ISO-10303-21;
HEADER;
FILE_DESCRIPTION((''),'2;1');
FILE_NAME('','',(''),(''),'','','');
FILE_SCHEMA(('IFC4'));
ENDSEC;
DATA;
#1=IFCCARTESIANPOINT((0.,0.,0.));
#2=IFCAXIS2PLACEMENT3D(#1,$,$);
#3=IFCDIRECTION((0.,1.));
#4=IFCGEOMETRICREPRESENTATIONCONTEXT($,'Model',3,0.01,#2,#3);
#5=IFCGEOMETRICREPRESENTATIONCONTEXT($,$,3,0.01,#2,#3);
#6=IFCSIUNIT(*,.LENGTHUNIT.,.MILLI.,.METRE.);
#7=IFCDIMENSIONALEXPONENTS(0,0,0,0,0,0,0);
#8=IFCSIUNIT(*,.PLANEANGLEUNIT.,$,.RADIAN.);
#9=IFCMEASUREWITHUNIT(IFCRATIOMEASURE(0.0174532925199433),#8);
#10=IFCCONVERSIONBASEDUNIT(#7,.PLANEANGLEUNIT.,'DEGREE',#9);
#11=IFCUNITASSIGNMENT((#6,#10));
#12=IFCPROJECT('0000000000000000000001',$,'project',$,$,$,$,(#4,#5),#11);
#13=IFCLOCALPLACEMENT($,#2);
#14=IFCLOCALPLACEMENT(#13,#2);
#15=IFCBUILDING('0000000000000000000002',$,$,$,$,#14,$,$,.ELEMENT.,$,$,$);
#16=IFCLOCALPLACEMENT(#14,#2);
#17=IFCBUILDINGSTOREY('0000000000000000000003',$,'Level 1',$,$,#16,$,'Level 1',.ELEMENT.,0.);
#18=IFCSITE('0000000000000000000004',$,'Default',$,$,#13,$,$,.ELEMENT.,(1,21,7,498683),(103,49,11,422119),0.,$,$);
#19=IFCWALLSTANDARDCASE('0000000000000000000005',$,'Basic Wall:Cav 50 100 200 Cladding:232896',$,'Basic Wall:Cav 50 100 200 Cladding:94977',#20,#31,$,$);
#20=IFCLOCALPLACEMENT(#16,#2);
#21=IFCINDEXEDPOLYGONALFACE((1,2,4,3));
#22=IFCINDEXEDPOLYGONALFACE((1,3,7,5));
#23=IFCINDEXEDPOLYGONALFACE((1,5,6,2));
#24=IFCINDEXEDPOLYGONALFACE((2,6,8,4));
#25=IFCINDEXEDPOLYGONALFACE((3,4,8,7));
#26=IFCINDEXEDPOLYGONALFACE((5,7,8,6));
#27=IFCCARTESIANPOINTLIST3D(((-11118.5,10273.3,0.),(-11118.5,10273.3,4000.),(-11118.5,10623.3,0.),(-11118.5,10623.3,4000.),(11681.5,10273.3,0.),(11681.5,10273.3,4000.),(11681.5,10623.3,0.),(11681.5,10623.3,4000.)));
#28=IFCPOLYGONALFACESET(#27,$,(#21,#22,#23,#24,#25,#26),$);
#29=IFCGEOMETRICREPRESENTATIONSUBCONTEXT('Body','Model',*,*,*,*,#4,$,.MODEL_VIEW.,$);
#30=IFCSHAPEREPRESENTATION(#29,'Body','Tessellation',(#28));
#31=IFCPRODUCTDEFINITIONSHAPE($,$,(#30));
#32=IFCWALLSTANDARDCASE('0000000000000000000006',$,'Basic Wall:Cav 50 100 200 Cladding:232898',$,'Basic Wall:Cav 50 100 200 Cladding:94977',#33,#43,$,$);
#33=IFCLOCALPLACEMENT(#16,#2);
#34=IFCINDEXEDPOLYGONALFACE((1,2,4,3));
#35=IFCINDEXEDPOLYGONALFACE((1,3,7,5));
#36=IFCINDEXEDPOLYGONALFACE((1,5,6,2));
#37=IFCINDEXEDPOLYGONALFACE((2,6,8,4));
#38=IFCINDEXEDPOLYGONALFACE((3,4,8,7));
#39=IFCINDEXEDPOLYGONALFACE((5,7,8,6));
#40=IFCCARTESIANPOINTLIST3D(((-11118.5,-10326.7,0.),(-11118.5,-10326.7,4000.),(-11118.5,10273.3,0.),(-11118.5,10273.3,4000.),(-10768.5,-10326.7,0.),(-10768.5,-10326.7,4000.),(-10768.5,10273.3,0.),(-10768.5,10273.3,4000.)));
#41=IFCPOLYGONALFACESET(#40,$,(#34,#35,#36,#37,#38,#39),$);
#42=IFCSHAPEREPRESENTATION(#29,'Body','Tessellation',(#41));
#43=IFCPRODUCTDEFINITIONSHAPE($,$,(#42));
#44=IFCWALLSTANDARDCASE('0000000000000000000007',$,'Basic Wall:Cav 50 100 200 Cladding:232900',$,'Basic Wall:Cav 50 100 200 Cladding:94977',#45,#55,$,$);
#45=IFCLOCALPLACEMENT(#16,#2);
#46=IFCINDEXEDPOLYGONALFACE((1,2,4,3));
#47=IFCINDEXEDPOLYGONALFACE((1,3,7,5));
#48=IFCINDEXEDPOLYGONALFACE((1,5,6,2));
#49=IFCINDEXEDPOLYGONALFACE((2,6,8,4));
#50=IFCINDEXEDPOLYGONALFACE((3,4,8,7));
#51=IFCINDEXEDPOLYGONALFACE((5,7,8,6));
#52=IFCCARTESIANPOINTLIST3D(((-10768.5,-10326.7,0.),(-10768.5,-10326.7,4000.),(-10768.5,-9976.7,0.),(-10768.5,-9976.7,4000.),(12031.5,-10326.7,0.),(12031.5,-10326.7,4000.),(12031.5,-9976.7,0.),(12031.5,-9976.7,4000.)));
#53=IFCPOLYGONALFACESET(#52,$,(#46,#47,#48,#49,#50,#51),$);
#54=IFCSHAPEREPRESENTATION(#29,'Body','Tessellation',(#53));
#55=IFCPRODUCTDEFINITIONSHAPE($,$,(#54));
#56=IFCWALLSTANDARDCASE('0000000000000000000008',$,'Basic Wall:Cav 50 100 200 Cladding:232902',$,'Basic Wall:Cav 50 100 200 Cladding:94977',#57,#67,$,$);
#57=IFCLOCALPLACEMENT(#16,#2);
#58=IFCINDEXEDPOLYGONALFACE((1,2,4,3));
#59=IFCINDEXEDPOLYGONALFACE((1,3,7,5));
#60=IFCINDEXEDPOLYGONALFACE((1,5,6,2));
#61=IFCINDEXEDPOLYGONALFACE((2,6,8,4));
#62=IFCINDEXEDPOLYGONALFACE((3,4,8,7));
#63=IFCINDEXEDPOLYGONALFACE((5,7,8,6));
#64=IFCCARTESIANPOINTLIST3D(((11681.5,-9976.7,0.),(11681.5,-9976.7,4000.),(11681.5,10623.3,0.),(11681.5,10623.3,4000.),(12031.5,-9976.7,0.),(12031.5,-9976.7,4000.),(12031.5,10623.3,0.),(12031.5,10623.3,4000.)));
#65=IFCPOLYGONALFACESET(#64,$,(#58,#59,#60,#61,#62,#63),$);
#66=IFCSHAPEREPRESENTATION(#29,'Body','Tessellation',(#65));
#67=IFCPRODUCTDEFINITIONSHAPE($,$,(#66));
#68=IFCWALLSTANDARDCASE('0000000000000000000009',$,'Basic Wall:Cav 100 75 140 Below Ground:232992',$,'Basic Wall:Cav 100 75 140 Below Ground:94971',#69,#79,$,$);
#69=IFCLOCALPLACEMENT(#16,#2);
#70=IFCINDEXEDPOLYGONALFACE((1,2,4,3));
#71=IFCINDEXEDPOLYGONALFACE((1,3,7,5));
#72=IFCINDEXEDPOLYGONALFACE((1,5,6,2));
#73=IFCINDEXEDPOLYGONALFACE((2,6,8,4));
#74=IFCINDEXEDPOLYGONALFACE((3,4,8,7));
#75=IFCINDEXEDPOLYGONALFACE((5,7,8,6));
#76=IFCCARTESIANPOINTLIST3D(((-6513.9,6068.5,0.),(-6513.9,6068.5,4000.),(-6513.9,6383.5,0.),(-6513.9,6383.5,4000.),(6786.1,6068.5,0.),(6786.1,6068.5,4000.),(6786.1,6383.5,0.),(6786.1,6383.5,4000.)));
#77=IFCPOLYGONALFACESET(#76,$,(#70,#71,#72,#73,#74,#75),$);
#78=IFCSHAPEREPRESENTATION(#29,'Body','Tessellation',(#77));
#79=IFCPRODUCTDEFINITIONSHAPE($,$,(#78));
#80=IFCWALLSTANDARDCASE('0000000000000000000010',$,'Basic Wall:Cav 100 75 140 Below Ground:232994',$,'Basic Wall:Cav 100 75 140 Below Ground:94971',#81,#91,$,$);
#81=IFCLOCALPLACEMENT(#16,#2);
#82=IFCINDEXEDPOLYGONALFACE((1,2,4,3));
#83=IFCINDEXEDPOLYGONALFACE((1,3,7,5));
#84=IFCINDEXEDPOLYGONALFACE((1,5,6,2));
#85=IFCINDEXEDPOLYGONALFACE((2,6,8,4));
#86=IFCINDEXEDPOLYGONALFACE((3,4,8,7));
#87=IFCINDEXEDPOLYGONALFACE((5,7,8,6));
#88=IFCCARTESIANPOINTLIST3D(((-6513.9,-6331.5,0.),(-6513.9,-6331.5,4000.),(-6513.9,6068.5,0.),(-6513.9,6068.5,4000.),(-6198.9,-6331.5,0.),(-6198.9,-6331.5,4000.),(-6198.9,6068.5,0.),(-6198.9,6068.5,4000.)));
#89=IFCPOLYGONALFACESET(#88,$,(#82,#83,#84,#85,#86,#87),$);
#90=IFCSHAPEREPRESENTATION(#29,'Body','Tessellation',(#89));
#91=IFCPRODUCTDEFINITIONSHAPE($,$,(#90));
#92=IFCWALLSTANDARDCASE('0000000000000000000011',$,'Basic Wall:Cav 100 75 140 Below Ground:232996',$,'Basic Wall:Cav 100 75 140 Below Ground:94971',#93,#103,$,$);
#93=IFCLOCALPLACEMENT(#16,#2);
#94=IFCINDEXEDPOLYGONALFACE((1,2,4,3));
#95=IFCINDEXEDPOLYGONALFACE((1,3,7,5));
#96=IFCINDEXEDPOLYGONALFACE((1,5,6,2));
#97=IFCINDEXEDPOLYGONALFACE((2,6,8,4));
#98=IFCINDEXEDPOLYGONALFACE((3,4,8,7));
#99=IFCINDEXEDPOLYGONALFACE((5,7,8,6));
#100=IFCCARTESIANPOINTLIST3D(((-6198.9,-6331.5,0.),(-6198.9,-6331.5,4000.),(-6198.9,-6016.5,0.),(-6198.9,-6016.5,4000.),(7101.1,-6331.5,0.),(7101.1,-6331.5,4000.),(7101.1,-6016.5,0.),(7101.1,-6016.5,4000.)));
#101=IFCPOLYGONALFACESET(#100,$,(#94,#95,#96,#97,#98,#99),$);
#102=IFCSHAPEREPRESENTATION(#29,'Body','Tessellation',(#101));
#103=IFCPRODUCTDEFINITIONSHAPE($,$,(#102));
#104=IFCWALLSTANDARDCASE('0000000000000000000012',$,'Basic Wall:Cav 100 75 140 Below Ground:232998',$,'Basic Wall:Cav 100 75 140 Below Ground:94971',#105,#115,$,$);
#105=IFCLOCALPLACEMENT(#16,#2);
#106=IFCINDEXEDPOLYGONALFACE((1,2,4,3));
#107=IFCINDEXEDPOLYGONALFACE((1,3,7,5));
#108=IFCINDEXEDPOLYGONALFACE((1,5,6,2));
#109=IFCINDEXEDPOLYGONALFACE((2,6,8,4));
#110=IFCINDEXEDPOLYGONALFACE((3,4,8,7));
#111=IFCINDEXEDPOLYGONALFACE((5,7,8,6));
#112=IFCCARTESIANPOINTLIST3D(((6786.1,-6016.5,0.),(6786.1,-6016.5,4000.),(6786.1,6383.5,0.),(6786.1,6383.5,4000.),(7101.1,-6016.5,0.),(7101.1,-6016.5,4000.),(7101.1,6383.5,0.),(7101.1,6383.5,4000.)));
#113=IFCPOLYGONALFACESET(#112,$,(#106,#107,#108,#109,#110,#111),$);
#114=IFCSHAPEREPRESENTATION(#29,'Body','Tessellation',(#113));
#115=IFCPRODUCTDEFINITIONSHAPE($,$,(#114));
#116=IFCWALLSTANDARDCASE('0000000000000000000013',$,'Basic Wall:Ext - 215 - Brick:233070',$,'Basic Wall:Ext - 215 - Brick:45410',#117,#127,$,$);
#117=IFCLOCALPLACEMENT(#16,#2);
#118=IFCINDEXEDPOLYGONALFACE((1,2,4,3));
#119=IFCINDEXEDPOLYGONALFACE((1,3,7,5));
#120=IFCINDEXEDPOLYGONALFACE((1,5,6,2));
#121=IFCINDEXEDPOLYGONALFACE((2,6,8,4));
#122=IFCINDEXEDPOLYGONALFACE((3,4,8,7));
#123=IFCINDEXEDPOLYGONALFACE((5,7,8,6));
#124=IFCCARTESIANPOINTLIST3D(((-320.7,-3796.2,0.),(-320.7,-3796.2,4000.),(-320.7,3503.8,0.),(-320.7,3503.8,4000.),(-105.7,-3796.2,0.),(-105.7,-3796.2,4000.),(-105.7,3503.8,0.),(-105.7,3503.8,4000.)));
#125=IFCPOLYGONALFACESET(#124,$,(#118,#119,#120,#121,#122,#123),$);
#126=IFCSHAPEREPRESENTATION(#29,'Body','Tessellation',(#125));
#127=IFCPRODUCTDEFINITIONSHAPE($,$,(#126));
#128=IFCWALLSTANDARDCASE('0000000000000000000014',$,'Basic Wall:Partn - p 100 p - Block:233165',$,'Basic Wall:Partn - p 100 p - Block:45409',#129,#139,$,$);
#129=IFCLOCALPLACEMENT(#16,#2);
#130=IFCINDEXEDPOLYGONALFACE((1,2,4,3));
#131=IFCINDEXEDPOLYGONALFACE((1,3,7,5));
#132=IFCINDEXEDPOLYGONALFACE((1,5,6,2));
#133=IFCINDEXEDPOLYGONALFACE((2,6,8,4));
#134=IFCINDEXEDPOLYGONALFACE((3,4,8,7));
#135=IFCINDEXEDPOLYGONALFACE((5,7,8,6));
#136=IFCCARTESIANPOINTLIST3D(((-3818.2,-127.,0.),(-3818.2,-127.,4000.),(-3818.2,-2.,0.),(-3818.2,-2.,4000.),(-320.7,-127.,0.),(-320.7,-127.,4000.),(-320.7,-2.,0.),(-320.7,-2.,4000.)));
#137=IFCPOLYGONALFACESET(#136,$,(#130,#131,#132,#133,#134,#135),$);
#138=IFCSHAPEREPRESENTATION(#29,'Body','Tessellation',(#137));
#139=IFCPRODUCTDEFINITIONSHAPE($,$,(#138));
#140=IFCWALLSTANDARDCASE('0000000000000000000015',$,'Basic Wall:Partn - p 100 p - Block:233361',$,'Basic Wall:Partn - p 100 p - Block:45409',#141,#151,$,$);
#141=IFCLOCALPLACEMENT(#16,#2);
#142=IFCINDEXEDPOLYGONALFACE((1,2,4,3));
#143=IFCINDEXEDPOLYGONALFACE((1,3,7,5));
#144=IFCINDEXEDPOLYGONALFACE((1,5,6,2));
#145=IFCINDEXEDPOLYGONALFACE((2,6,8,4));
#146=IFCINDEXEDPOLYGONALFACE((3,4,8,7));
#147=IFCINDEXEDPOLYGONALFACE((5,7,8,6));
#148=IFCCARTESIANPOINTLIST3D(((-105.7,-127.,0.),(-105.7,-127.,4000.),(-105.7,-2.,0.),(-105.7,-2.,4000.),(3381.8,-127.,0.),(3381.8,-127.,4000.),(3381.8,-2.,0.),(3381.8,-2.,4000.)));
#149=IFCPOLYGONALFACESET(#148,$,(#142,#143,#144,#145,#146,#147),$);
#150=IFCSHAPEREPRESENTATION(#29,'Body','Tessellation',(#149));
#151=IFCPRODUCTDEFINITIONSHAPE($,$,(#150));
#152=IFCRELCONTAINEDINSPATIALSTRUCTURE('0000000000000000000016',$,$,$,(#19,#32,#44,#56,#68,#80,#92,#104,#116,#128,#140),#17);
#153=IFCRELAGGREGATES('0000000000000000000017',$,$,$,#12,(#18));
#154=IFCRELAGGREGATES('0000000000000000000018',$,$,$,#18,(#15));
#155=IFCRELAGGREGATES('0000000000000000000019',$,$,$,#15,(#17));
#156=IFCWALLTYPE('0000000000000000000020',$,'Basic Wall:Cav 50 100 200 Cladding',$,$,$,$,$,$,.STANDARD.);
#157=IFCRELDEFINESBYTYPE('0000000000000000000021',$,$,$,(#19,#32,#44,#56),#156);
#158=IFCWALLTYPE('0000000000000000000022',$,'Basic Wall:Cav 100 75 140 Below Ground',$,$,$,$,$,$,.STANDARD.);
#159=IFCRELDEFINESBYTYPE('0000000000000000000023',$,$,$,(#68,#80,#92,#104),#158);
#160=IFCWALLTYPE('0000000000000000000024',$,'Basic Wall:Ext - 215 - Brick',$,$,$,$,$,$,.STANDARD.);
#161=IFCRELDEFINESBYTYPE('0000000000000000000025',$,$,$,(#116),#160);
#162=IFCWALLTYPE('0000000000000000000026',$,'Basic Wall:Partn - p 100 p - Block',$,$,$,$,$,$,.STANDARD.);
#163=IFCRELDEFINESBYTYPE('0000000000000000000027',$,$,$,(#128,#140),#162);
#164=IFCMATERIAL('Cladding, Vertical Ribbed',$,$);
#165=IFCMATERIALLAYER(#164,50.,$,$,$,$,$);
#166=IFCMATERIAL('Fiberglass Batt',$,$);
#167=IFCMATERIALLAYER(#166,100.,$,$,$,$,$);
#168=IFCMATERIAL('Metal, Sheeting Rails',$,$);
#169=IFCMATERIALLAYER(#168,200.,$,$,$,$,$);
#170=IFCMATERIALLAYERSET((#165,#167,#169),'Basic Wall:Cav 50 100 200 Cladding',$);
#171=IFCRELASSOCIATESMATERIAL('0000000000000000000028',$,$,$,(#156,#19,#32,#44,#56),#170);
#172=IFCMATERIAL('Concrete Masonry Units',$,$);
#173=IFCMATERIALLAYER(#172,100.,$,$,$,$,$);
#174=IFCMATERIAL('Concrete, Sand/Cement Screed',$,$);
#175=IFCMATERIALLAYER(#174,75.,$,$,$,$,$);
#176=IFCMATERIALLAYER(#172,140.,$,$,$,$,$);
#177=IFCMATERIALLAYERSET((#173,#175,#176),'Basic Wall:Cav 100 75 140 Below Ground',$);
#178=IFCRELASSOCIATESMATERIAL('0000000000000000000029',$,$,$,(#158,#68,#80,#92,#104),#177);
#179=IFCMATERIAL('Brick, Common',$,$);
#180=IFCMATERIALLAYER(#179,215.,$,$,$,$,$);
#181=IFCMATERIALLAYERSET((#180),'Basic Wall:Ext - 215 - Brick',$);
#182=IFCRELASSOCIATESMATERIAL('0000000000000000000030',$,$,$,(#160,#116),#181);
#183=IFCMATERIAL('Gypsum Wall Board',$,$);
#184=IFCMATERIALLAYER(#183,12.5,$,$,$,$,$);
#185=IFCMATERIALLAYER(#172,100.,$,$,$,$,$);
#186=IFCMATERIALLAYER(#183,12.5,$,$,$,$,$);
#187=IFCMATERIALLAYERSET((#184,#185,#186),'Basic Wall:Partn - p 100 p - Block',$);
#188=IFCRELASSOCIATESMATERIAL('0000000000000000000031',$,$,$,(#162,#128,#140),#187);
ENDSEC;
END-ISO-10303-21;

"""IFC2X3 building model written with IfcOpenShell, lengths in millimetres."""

from ifc_helpers import new_model, entity, si_unit, converted_unit, direction, frame, frame_2d, origin, place, context, subcontext, project, spatial, rectangle, extrude, material, layer, layer_set, layer_usage, type_object, element, save


model = new_model("IFC2X3")

# Units and contexts
model_context = context("Model", 3, precision=0.01, world=origin(), true_north=direction((0.0, 1.0)))
context_of_model = context(None, 3, precision=0.01, world=origin(), true_north=direction((0.0, 1.0)))
body_context = subcontext(model_context, "Body", "Model", "MODEL_VIEW")
ifc_project = project(units=[si_unit("LENGTHUNIT", "METRE", prefix="MILLI"), converted_unit("PLANEANGLEUNIT", "DEGREE", entity("IfcRatioMeasure", 0.0174532925199433), si_unit("PLANEANGLEUNIT", "RADIAN"), dimensions=[0, 0, 0, 0, 0, 0, 0])], contexts=[model_context, context_of_model])

# Site, building, storey
site_placement = place(None, origin())
site = spatial("IfcSite", under=ifc_project, at=site_placement, Name="Default", CompositionType="ELEMENT", RefLatitude=(1, 21, 7, 498683), RefLongitude=(103, 49, 11, 422119), RefElevation=0.0)
building_placement = place(site_placement, origin())
building = spatial("IfcBuilding", under=site, at=building_placement, CompositionType="ELEMENT")
storey_placement = place(building_placement, origin())
storey = spatial("IfcBuildingStorey", under=building, at=storey_placement, Name="Level 1", LongName="Level 1", CompositionType="ELEMENT", Elevation=0.0)

# Walls
ifc_material_1 = material(Name="Cladding, Vertical Ribbed")
ifc_layer_1 = layer(ifc_material_1, 50.0)
ifc_material_2 = material(Name="Fiberglass Batt")
ifc_layer_2 = layer(ifc_material_2, 100.0)
ifc_material_3 = material(Name="Metal, Sheeting Rails")
ifc_layer_3 = layer(ifc_material_3, 200.0)
ifc_layer_set_1 = layer_set([ifc_layer_1, ifc_layer_2, ifc_layer_3], Name="Basic Wall:Cav 50 100 200 Cladding")
ifc_layer_usage_1 = layer_usage(ifc_layer_set_1, "AXIS2", "NEGATIVE", 175.0)
wall_type_1 = type_object("IfcWallType", Name="Basic Wall:Cav 50 100 200 Cladding", PredefinedType="STANDARD", material=ifc_layer_set_1)
wall_1_placement = place(storey_placement, frame((-11118.5, 10448.3, 0.0)))
element("IfcWallStandardCase", 1, at=wall_1_placement, inside=storey, type_object=wall_type_1, material=ifc_layer_usage_1, Name="Basic Wall:Cav 50 100 200 Cladding:232896", ObjectType="Basic Wall:Cav 50 100 200 Cladding:94977", context=body_context, shape_type="SweptSolid", body=[
    extrude(rectangle(XDim=22800.0, YDim=350.0, at=frame_2d((11400.0, 0.0), x_axis=(-1.0, 0.0))), origin(), (0.0, 0.0, 1.0), 4000.0),
])
ifc_layer_usage_2 = layer_usage(ifc_layer_set_1, "AXIS2", "NEGATIVE", 175.0)
wall_2_placement = place(storey_placement, frame((-10943.5, -10326.7, 0.0), z_axis=(0.0, 0.0, 1.0), x_axis=(0.0, 1.0, 0.0)))
element("IfcWallStandardCase", 2, at=wall_2_placement, inside=storey, type_object=wall_type_1, material=ifc_layer_usage_2, Name="Basic Wall:Cav 50 100 200 Cladding:232898", ObjectType="Basic Wall:Cav 50 100 200 Cladding:94977", context=body_context, shape_type="SweptSolid", body=[
    extrude(rectangle(XDim=20600.0, YDim=350.0, at=frame_2d((10300.0, 0.0), x_axis=(-1.0, 0.0))), origin(), (0.0, 0.0, 1.0), 4000.0),
])
ifc_layer_usage_3 = layer_usage(ifc_layer_set_1, "AXIS2", "NEGATIVE", 175.0)
wall_3_placement = place(storey_placement, frame((12031.5, -10151.7, 0.0), z_axis=(0.0, 0.0, 1.0), x_axis=(-1.0, 0.0, 0.0)))
element("IfcWallStandardCase", 3, at=wall_3_placement, inside=storey, type_object=wall_type_1, material=ifc_layer_usage_3, Name="Basic Wall:Cav 50 100 200 Cladding:232900", ObjectType="Basic Wall:Cav 50 100 200 Cladding:94977", context=body_context, shape_type="SweptSolid", body=[
    extrude(rectangle(XDim=22800.0, YDim=350.0, at=frame_2d((11400.0, 0.0), x_axis=(-1.0, 0.0))), origin(), (0.0, 0.0, 1.0), 4000.0),
])
ifc_layer_usage_4 = layer_usage(ifc_layer_set_1, "AXIS2", "NEGATIVE", 175.0)
wall_4_placement = place(storey_placement, frame((11856.5, 10623.3, 0.0), z_axis=(0.0, 0.0, 1.0), x_axis=(0.0, -1.0, 0.0)))
element("IfcWallStandardCase", 4, at=wall_4_placement, inside=storey, type_object=wall_type_1, material=ifc_layer_usage_4, Name="Basic Wall:Cav 50 100 200 Cladding:232902", ObjectType="Basic Wall:Cav 50 100 200 Cladding:94977", context=body_context, shape_type="SweptSolid", body=[
    extrude(rectangle(XDim=20600.0, YDim=350.0, at=frame_2d((10300.0, 0.0), x_axis=(-1.0, 0.0))), origin(), (0.0, 0.0, 1.0), 4000.0),
])
ifc_material_4 = material(Name="Concrete Masonry Units")
ifc_layer_4 = layer(ifc_material_4, 100.0)
ifc_material_5 = material(Name="Concrete, Sand/Cement Screed")
ifc_layer_5 = layer(ifc_material_5, 75.0)
ifc_layer_6 = layer(ifc_material_4, 140.0)
ifc_layer_set_2 = layer_set([ifc_layer_4, ifc_layer_5, ifc_layer_6], Name="Basic Wall:Cav 100 75 140 Below Ground")
ifc_layer_usage_5 = layer_usage(ifc_layer_set_2, "AXIS2", "NEGATIVE", 157.5)
wall_type_2 = type_object("IfcWallType", Name="Basic Wall:Cav 100 75 140 Below Ground", PredefinedType="STANDARD", material=ifc_layer_set_2)
wall_5_placement = place(storey_placement, frame((-6513.9, 6226.0, 0.0)))
element("IfcWallStandardCase", 5, at=wall_5_placement, inside=storey, type_object=wall_type_2, material=ifc_layer_usage_5, Name="Basic Wall:Cav 100 75 140 Below Ground:232992", ObjectType="Basic Wall:Cav 100 75 140 Below Ground:94971", context=body_context, shape_type="SweptSolid", body=[
    extrude(rectangle(XDim=13300.0, YDim=315.0, at=frame_2d((6650.0, 0.0), x_axis=(-1.0, 0.0))), origin(), (0.0, 0.0, 1.0), 4000.0),
])
ifc_layer_usage_6 = layer_usage(ifc_layer_set_2, "AXIS2", "NEGATIVE", 157.5)
wall_6_placement = place(storey_placement, frame((-6356.4, -6331.5, 0.0), z_axis=(0.0, 0.0, 1.0), x_axis=(0.0, 1.0, 0.0)))
element("IfcWallStandardCase", 6, at=wall_6_placement, inside=storey, type_object=wall_type_2, material=ifc_layer_usage_6, Name="Basic Wall:Cav 100 75 140 Below Ground:232994", ObjectType="Basic Wall:Cav 100 75 140 Below Ground:94971", context=body_context, shape_type="SweptSolid", body=[
    extrude(rectangle(XDim=12400.0, YDim=315.0, at=frame_2d((6200.0, 0.0), x_axis=(-1.0, 0.0))), origin(), (0.0, 0.0, 1.0), 4000.0),
])
ifc_layer_usage_7 = layer_usage(ifc_layer_set_2, "AXIS2", "NEGATIVE", 157.5)
wall_7_placement = place(storey_placement, frame((7101.1, -6174.0, 0.0), z_axis=(0.0, 0.0, 1.0), x_axis=(-1.0, 0.0, 0.0)))
element("IfcWallStandardCase", 7, at=wall_7_placement, inside=storey, type_object=wall_type_2, material=ifc_layer_usage_7, Name="Basic Wall:Cav 100 75 140 Below Ground:232996", ObjectType="Basic Wall:Cav 100 75 140 Below Ground:94971", context=body_context, shape_type="SweptSolid", body=[
    extrude(rectangle(XDim=13300.0, YDim=315.0, at=frame_2d((6650.0, 0.0), x_axis=(-1.0, 0.0))), origin(), (0.0, 0.0, 1.0), 4000.0),
])
ifc_layer_usage_8 = layer_usage(ifc_layer_set_2, "AXIS2", "NEGATIVE", 157.5)
wall_8_placement = place(storey_placement, frame((6943.6, 6383.5, 0.0), z_axis=(0.0, 0.0, 1.0), x_axis=(0.0, -1.0, 0.0)))
element("IfcWallStandardCase", 8, at=wall_8_placement, inside=storey, type_object=wall_type_2, material=ifc_layer_usage_8, Name="Basic Wall:Cav 100 75 140 Below Ground:232998", ObjectType="Basic Wall:Cav 100 75 140 Below Ground:94971", context=body_context, shape_type="SweptSolid", body=[
    extrude(rectangle(XDim=12400.0, YDim=315.0, at=frame_2d((6200.0, 0.0), x_axis=(-1.0, 0.0))), origin(), (0.0, 0.0, 1.0), 4000.0),
])
ifc_material_6 = material(Name="Brick, Common")
ifc_layer_7 = layer(ifc_material_6, 215.0)
ifc_layer_set_3 = layer_set([ifc_layer_7], Name="Basic Wall:Ext - 215 - Brick")
ifc_layer_usage_9 = layer_usage(ifc_layer_set_3, "AXIS2", "NEGATIVE", 107.5)
wall_type_3 = type_object("IfcWallType", Name="Basic Wall:Ext - 215 - Brick", PredefinedType="STANDARD", material=ifc_layer_set_3)
wall_9_placement = place(storey_placement, frame((-213.2, 3503.8, 0.0), z_axis=(0.0, 0.0, 1.0), x_axis=(0.0, -1.0, 0.0)))
element("IfcWallStandardCase", 9, at=wall_9_placement, inside=storey, type_object=wall_type_3, material=ifc_layer_usage_9, Name="Basic Wall:Ext - 215 - Brick:233070", ObjectType="Basic Wall:Ext - 215 - Brick:45410", context=body_context, shape_type="SweptSolid", body=[
    extrude(rectangle(XDim=7300.0, YDim=215.0, at=frame_2d((3650.0, 0.0), x_axis=(-1.0, 0.0))), origin(), (0.0, 0.0, 1.0), 4000.0),
])
ifc_material_7 = material(Name="Gypsum Wall Board")
ifc_layer_8 = layer(ifc_material_7, 12.5)
ifc_layer_9 = layer(ifc_material_4, 100.0)
ifc_layer_10 = layer(ifc_material_7, 12.5)
ifc_layer_set_4 = layer_set([ifc_layer_8, ifc_layer_9, ifc_layer_10], Name="Basic Wall:Partn - p 100 p - Block")
ifc_layer_usage_10 = layer_usage(ifc_layer_set_4, "AXIS2", "NEGATIVE", 62.5)
wall_type_4 = type_object("IfcWallType", Name="Basic Wall:Partn - p 100 p - Block", PredefinedType="STANDARD", material=ifc_layer_set_4)
wall_10_placement = place(storey_placement, frame((-3818.2, -64.5, 0.0)))
element("IfcWallStandardCase", 10, at=wall_10_placement, inside=storey, type_object=wall_type_4, material=ifc_layer_usage_10, Name="Basic Wall:Partn - p 100 p - Block:233165", ObjectType="Basic Wall:Partn - p 100 p - Block:45409", context=body_context, shape_type="SweptSolid", body=[
    extrude(rectangle(XDim=3497.5, YDim=125.0, at=frame_2d((1748.8, 0.0), x_axis=(-1.0, 0.0))), origin(), (0.0, 0.0, 1.0), 4000.0),
])
ifc_layer_usage_11 = layer_usage(ifc_layer_set_4, "AXIS2", "NEGATIVE", 62.5)
wall_11_placement = place(storey_placement, frame((-105.7, -64.5, 0.0)))
element("IfcWallStandardCase", 11, at=wall_11_placement, inside=storey, type_object=wall_type_4, material=ifc_layer_usage_11, Name="Basic Wall:Partn - p 100 p - Block:233361", ObjectType="Basic Wall:Partn - p 100 p - Block:45409", context=body_context, shape_type="SweptSolid", body=[
    extrude(rectangle(XDim=3487.5, YDim=125.0, at=frame_2d((1743.7, 0.0), x_axis=(-1.0, 0.0))), origin(), (0.0, 0.0, 1.0), 4000.0),
])

save(model, "model.ifc")
